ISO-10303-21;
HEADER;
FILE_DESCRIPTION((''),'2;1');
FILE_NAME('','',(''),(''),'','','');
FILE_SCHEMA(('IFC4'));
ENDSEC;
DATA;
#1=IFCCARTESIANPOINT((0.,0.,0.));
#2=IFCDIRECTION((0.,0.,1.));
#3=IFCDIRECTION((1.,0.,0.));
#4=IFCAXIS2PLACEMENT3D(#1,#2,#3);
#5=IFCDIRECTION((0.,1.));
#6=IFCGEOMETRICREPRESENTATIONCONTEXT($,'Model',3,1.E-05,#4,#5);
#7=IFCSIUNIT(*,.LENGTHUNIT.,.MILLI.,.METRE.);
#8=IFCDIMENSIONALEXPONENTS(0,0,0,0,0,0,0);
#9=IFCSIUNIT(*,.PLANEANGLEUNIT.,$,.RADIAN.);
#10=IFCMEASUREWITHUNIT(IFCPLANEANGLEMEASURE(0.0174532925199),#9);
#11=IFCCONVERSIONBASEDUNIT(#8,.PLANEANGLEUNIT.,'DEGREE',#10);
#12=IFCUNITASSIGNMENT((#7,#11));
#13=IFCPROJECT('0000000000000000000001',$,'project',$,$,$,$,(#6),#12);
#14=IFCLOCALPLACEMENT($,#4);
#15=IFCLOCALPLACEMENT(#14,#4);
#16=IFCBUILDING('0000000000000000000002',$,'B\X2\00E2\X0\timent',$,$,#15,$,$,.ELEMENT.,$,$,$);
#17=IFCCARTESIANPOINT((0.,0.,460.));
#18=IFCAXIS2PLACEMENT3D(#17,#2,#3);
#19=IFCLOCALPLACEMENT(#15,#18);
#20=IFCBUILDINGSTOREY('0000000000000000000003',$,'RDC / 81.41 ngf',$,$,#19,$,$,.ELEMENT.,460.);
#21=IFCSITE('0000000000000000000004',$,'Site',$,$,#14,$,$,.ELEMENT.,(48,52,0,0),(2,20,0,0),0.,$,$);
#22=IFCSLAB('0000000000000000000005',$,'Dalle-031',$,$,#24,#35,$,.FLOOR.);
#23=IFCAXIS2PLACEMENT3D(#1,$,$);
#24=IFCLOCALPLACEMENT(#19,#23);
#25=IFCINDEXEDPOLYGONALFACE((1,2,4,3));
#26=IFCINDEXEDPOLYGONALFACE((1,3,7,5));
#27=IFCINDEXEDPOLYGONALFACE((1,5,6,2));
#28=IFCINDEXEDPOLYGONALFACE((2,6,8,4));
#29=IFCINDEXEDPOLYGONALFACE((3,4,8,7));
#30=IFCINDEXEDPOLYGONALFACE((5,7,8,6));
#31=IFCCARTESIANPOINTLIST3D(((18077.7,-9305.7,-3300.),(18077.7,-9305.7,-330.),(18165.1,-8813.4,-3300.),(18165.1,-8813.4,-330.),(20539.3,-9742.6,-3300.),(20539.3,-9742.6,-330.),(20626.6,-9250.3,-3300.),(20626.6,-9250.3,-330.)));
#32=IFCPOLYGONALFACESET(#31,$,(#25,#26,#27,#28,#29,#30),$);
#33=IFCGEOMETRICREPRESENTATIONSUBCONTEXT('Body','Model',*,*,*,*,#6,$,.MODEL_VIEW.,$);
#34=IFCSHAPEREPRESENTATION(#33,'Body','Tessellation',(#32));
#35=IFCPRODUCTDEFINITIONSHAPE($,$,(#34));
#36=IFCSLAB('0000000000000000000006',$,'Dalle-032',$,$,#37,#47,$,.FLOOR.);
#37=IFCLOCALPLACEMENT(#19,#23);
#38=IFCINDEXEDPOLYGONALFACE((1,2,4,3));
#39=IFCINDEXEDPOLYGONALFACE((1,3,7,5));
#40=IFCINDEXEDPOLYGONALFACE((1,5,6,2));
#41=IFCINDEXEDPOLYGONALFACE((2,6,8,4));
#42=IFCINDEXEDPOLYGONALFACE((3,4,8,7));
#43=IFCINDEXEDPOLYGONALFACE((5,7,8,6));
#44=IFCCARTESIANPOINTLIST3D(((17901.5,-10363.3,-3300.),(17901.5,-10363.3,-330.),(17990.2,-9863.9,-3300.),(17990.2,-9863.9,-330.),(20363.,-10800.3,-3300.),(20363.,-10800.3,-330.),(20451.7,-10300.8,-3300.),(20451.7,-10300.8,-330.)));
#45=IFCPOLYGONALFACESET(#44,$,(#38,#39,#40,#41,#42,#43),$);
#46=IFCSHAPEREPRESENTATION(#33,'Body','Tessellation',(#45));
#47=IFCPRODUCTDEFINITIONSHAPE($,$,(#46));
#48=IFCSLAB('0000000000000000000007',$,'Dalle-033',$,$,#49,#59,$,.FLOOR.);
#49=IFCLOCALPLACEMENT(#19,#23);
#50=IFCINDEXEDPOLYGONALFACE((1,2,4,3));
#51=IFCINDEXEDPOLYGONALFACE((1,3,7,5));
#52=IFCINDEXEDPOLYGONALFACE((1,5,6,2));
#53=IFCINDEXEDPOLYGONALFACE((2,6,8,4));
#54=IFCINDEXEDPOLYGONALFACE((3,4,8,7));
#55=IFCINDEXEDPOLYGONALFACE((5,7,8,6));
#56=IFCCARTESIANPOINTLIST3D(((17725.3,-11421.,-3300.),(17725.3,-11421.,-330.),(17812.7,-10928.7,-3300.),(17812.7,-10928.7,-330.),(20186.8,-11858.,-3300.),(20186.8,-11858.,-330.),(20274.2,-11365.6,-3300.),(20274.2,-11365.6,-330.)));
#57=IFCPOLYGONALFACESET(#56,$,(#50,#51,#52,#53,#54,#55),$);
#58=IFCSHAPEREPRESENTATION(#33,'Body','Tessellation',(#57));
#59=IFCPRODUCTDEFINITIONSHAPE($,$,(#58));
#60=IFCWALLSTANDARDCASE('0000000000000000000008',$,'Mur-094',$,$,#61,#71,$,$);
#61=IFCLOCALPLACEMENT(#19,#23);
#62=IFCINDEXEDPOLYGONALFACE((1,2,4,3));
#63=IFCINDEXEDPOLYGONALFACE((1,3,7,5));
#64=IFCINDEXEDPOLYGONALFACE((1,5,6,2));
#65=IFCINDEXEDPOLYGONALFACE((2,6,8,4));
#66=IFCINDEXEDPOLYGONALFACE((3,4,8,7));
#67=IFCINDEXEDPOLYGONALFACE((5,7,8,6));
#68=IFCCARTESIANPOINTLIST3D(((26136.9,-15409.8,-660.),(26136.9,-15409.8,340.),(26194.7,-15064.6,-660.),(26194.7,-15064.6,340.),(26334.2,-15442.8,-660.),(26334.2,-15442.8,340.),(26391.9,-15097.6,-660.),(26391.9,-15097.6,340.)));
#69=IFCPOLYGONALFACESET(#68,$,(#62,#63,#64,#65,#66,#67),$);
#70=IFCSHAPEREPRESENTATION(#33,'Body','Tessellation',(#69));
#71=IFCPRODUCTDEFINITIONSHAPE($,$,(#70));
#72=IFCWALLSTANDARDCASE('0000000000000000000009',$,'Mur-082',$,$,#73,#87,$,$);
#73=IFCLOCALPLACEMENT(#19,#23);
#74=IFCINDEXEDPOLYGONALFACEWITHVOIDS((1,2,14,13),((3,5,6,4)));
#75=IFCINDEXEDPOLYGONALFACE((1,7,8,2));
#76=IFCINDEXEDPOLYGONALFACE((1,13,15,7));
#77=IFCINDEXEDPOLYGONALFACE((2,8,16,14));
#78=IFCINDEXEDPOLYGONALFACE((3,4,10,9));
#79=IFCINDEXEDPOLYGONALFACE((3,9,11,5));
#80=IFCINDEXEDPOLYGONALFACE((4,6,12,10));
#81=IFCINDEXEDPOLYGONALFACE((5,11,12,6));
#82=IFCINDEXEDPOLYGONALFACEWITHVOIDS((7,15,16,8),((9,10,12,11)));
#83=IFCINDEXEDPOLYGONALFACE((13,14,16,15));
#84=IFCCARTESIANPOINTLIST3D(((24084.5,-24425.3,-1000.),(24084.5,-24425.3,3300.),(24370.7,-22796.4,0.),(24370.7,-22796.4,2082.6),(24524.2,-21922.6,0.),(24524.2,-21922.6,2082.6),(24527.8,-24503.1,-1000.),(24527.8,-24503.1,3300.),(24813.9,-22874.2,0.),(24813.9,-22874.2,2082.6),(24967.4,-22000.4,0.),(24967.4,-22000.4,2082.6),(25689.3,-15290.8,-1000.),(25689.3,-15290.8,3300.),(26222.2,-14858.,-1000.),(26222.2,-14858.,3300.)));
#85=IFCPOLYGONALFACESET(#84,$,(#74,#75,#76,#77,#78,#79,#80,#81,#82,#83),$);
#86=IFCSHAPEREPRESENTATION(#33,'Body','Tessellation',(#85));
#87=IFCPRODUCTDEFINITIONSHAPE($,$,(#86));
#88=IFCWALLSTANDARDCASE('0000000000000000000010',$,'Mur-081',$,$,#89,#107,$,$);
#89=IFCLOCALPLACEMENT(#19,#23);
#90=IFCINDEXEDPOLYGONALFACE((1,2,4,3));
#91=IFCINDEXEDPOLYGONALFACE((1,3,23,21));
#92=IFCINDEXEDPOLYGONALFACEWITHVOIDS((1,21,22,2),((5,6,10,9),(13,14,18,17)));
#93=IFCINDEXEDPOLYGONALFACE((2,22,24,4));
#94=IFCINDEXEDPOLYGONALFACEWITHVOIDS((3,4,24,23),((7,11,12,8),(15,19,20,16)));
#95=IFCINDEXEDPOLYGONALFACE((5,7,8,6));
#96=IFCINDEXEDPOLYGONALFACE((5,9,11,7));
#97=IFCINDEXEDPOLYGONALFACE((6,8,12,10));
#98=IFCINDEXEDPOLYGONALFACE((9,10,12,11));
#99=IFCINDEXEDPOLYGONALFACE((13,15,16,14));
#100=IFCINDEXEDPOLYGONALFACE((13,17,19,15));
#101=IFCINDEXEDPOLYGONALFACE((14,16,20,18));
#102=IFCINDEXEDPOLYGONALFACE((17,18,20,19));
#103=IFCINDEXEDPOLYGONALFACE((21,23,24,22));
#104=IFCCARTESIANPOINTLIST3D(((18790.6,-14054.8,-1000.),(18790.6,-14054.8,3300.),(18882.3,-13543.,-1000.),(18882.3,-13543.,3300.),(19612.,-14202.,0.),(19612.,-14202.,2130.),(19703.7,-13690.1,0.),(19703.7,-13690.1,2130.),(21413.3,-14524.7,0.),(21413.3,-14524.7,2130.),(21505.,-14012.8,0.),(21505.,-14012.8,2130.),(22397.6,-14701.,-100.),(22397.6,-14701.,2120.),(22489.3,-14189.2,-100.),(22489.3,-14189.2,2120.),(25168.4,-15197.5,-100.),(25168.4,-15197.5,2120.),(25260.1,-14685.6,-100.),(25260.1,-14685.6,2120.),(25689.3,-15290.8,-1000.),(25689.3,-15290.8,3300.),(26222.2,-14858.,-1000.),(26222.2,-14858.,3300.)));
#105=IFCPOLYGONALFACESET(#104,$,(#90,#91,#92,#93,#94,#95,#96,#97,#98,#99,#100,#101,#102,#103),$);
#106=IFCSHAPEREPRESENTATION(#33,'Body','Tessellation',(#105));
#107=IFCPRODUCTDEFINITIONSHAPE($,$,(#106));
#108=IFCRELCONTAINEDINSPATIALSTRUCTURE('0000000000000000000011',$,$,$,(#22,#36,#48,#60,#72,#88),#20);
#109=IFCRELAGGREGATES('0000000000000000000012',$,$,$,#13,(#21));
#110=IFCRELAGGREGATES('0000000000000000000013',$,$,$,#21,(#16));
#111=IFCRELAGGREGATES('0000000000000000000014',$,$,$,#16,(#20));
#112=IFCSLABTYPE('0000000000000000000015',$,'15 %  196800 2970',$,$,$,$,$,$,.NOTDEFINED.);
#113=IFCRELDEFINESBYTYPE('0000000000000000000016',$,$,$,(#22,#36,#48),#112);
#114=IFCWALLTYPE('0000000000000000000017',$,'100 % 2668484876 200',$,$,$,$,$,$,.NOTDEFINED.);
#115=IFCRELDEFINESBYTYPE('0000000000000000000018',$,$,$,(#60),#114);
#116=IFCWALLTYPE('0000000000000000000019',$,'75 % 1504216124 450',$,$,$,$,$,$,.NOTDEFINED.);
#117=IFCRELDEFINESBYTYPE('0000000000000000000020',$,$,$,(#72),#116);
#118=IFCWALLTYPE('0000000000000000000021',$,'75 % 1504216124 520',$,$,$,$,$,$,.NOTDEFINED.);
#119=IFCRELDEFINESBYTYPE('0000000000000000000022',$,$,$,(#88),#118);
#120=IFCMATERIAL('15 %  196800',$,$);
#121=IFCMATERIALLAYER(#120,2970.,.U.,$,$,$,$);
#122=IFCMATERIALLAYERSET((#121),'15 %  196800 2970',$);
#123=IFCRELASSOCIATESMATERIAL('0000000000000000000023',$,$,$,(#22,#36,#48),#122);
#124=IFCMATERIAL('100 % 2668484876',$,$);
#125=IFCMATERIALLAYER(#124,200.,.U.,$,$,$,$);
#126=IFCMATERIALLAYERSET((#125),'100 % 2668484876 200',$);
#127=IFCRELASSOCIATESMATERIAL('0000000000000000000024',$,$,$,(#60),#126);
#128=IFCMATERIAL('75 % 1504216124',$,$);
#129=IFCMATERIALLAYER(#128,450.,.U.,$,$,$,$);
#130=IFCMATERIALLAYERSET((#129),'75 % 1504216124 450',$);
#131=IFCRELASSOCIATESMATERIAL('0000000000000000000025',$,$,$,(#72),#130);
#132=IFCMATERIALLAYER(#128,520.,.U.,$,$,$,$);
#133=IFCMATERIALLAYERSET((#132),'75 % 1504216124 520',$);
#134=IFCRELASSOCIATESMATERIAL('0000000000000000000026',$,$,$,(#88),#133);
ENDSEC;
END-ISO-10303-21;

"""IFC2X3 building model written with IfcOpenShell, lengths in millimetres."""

from ifc_helpers import new_model, entity, si_unit, converted_unit, direction, frame, origin_with_axes, origin_2d_with_axis, place, context, subcontext, project, spatial, polyline, rectangle, outline, extrude, material, layer, layer_set, layer_usage, type_object, element, save


model = new_model("IFC2X3")

# Units and contexts
model_context = context("Model", 3, precision=1e-05, world=origin_with_axes(), true_north=direction((0.0, 1.0)))
body_context = subcontext(model_context, "Body", "Model", "MODEL_VIEW")
ifc_project = project(units=[si_unit("LENGTHUNIT", "METRE", prefix="MILLI"), converted_unit("PLANEANGLEUNIT", "DEGREE", entity("IfcPlaneAngleMeasure", 0.0174532925199), si_unit("PLANEANGLEUNIT", "RADIAN"), dimensions=[0, 0, 0, 0, 0, 0, 0])], contexts=[model_context])

# Site, building, storey
site_placement = place(None, origin_with_axes())
site = spatial("IfcSite", under=ifc_project, at=site_placement, Name="Site", CompositionType="ELEMENT", RefLatitude=(48, 52, 0, 0), RefLongitude=(2, 20, 0, 0), RefElevation=0.0)
building_placement = place(site_placement, origin_with_axes())
building = spatial("IfcBuilding", under=site, at=building_placement, Name="Bâtiment", CompositionType="ELEMENT")
storey_placement = place(building_placement, frame((0.0, 0.0, 460.0), z_axis=(0.0, 0.0, 1.0), x_axis=(1.0, 0.0, 0.0)))
storey = spatial("IfcBuildingStorey", under=building, at=storey_placement, Name="RDC / 81.41 ngf", CompositionType="ELEMENT", Elevation=460.0)

# Slabs
ifc_material_1 = material(Name="100 % 2668484876")
ifc_material_2 = material(Name="15 %  196800")
ifc_layer_1 = layer(ifc_material_2, 2970.0, ventilated="UNKNOWN")
ifc_layer_set_1 = layer_set([ifc_layer_1], Name="15 %  196800 2970")
slab_type_1 = type_object("IfcSlabType", Name="15 %  196800 2970", PredefinedType="NOTDEFINED")
ifc_layer_usage_1 = layer_usage(ifc_layer_set_1, "AXIS3", "NEGATIVE", 2970.0)
slab_1_placement = place(storey_placement, frame((20626.6, -9250.3, -330.0), z_axis=(0.0, 0.0, 1.0), x_axis=(1.0, 0.0, 0.0)))
element("IfcSlab", 1, at=slab_1_placement, inside=storey, type_object=slab_type_1, material=ifc_layer_usage_1, Name="Dalle-031", PredefinedType="FLOOR", context=body_context, shape_type="SweptSolid", body=[
    extrude(outline(polyline([(0.0, 0.0), (-2461.5, 437.0), (-2548.9, -55.4), (-87.4, -492.3), (0.0, 0.0)])), frame((0.0, 0.0, -2970.0), z_axis=(0.0, 0.0, 1.0), x_axis=(1.0, 0.0, 0.0)), (0.0, 0.0, 1.0), 2970.0),
])
ifc_layer_usage_2 = layer_usage(ifc_layer_set_1, "AXIS3", "NEGATIVE", 2970.0)
slab_2_placement = place(storey_placement, frame((20363.0, -10800.3, -330.0), z_axis=(0.0, 0.0, 1.0), x_axis=(1.0, 0.0, 0.0)))
element("IfcSlab", 2, at=slab_2_placement, inside=storey, type_object=slab_type_1, material=ifc_layer_usage_2, Name="Dalle-032", PredefinedType="FLOOR", context=body_context, shape_type="SweptSolid", body=[
    extrude(outline(polyline([(0.0, 0.0), (88.7, 499.4), (-2372.9, 936.4), (-2461.5, 437.0), (0.0, 0.0)])), frame((0.0, 0.0, -2970.0), z_axis=(0.0, 0.0, 1.0), x_axis=(1.0, 0.0, 0.0)), (0.0, 0.0, 1.0), 2970.0),
])
ifc_layer_usage_3 = layer_usage(ifc_layer_set_1, "AXIS3", "NEGATIVE", 2970.0)
slab_3_placement = place(storey_placement, frame((20186.8, -11858.0, -330.0), z_axis=(0.0, 0.0, 1.0), x_axis=(1.0, 0.0, 0.0)))
element("IfcSlab", 3, at=slab_3_placement, inside=storey, type_object=slab_type_1, material=ifc_layer_usage_3, Name="Dalle-033", PredefinedType="FLOOR", context=body_context, shape_type="SweptSolid", body=[
    extrude(outline(polyline([(0.0, 0.0), (87.4, 492.3), (-2374.1, 929.3), (-2461.5, 437.0), (0.0, 0.0)])), frame((0.0, 0.0, -2970.0), z_axis=(0.0, 0.0, 1.0), x_axis=(1.0, 0.0, 0.0)), (0.0, 0.0, 1.0), 2970.0),
])

# Wall
ifc_layer_2 = layer(ifc_material_1, 200.0, ventilated="UNKNOWN")
ifc_layer_set_2 = layer_set([ifc_layer_2], Name="100 % 2668484876 200")
ifc_layer_usage_4 = layer_usage(ifc_layer_set_2, "AXIS2", "NEGATIVE", 200.0)
wall_type_1 = type_object("IfcWallType", Name="100 % 2668484876 200", PredefinedType="NOTDEFINED")
wall_1_placement = place(storey_placement, frame((26194.7, -15064.6, -660.0), z_axis=(0.0, 0.0, 1.0), x_axis=(-0.165016, -0.986291, 0.0)))
element("IfcWallStandardCase", 4, at=wall_1_placement, inside=storey, type_object=wall_type_1, material=ifc_layer_usage_4, Name="Mur-094", context=body_context, shape_type="SweptSolid", body=[
    extrude(outline(polyline([(0.0, 0.0), (350.0, 0.0), (350.0, 200.0), (0.0, 200.0), (0.0, 0.0)])), origin_with_axes(), (0.0, 0.0, 1.0), 1000.0),
])

# Wall, opening
ifc_material_3 = material(Name="75 % 1504216124")
ifc_layer_3 = layer(ifc_material_3, 450.0, ventilated="UNKNOWN")
ifc_layer_set_3 = layer_set([ifc_layer_3], Name="75 % 1504216124 450")
ifc_layer_usage_5 = layer_usage(ifc_layer_set_3, "AXIS2", "NEGATIVE", 450.0)
wall_type_2 = type_object("IfcWallType", Name="75 % 1504216124 450", PredefinedType="NOTDEFINED")
wall_2_placement = place(storey_placement, frame((25689.3, -15290.8, -1000.0), z_axis=(0.0, 0.0, 1.0), x_axis=(-0.173028, -0.984917, 0.0)))
wall_2 = element("IfcWallStandardCase", 5, at=wall_2_placement, inside=storey, type_object=wall_type_2, material=ifc_layer_usage_5, Name="Mur-082", context=body_context, shape_type="SweptSolid", body=[
    extrude(outline(polyline([(0.0, 0.0), (9274.4, 0.0), (9274.3, 450.0), (-518.5, 450.0), (0.0, 0.0)])), origin_with_axes(), (0.0, 0.0, 1.0), 4300.0),
])
opening_1_placement = place(wall_2_placement, frame((7177.0, 0.0, 1000.0), z_axis=(0.0, 0.0, 1.0), x_axis=(1.0, 0.0, 0.0)))
element("IfcOpeningElement", 6, at=opening_1_placement, cuts=wall_2, context=body_context, shape_type="SweptSolid", body=[
    extrude(rectangle(XDim=887.2, YDim=2082.6, at=origin_2d_with_axis()), frame((0.0, -450.0, 1041.3), z_axis=(0.0, -1.0, 0.0), x_axis=(1.0, 0.0, 0.0)), (0.0, 0.0, -1.0), 1350.0),
])

# Wall, openings
ifc_layer_4 = layer(ifc_material_3, 520.0, ventilated="UNKNOWN")
ifc_layer_set_4 = layer_set([ifc_layer_4], Name="75 % 1504216124 520")
ifc_layer_usage_6 = layer_usage(ifc_layer_set_4, "AXIS2", "POSITIVE", 0.0)
wall_type_3 = type_object("IfcWallType", Name="75 % 1504216124 520", PredefinedType="NOTDEFINED")
wall_3_placement = place(storey_placement, frame((18790.6, -14054.8, -1000.0), z_axis=(0.0, 0.0, 1.0), x_axis=(0.984328, -0.176349, 0.0)))
wall_3 = element("IfcWallStandardCase", 7, at=wall_3_placement, inside=storey, type_object=wall_type_3, material=ifc_layer_usage_6, Name="Mur-081", context=body_context, shape_type="SweptSolid", body=[
    extrude(outline(polyline([(0.0, 0.0), (7008.5, 0.0), (7456.8, 520.0), (0.0, 520.0), (0.0, 0.0)])), origin_with_axes(), (0.0, 0.0, 1.0), 4300.0),
])
opening_2_placement = place(wall_3_placement, frame((1749.5, 0.0, 1000.0), z_axis=(0.0, 0.0, 1.0), x_axis=(1.0, 0.0, 0.0)))
element("IfcOpeningElement", 8, at=opening_2_placement, cuts=wall_3, context=body_context, shape_type="SweptSolid", body=[
    extrude(rectangle(XDim=1830.0, YDim=2130.0, at=origin_2d_with_axis()), frame((0.0, -520.0, 1065.0), z_axis=(0.0, -1.0, 0.0), x_axis=(1.0, 0.0, 0.0)), (0.0, 0.0, -1.0), 1560.0),
])
opening_3_placement = place(wall_3_placement, frame((5071.9, 0.0, 900.0), z_axis=(0.0, 0.0, 1.0), x_axis=(1.0, 0.0, 0.0)))
element("IfcOpeningElement", 9, at=opening_3_placement, cuts=wall_3, context=body_context, shape_type="SweptSolid", body=[
    extrude(rectangle(XDim=2814.9, YDim=2220.0, at=origin_2d_with_axis()), frame((0.0, -520.0, 1110.0), z_axis=(0.0, 1.0, 0.0), x_axis=(-1.0, 0.0, 0.0)), (0.0, 0.0, 1.0), 1560.0),
])

save(model, "model.ifc")
